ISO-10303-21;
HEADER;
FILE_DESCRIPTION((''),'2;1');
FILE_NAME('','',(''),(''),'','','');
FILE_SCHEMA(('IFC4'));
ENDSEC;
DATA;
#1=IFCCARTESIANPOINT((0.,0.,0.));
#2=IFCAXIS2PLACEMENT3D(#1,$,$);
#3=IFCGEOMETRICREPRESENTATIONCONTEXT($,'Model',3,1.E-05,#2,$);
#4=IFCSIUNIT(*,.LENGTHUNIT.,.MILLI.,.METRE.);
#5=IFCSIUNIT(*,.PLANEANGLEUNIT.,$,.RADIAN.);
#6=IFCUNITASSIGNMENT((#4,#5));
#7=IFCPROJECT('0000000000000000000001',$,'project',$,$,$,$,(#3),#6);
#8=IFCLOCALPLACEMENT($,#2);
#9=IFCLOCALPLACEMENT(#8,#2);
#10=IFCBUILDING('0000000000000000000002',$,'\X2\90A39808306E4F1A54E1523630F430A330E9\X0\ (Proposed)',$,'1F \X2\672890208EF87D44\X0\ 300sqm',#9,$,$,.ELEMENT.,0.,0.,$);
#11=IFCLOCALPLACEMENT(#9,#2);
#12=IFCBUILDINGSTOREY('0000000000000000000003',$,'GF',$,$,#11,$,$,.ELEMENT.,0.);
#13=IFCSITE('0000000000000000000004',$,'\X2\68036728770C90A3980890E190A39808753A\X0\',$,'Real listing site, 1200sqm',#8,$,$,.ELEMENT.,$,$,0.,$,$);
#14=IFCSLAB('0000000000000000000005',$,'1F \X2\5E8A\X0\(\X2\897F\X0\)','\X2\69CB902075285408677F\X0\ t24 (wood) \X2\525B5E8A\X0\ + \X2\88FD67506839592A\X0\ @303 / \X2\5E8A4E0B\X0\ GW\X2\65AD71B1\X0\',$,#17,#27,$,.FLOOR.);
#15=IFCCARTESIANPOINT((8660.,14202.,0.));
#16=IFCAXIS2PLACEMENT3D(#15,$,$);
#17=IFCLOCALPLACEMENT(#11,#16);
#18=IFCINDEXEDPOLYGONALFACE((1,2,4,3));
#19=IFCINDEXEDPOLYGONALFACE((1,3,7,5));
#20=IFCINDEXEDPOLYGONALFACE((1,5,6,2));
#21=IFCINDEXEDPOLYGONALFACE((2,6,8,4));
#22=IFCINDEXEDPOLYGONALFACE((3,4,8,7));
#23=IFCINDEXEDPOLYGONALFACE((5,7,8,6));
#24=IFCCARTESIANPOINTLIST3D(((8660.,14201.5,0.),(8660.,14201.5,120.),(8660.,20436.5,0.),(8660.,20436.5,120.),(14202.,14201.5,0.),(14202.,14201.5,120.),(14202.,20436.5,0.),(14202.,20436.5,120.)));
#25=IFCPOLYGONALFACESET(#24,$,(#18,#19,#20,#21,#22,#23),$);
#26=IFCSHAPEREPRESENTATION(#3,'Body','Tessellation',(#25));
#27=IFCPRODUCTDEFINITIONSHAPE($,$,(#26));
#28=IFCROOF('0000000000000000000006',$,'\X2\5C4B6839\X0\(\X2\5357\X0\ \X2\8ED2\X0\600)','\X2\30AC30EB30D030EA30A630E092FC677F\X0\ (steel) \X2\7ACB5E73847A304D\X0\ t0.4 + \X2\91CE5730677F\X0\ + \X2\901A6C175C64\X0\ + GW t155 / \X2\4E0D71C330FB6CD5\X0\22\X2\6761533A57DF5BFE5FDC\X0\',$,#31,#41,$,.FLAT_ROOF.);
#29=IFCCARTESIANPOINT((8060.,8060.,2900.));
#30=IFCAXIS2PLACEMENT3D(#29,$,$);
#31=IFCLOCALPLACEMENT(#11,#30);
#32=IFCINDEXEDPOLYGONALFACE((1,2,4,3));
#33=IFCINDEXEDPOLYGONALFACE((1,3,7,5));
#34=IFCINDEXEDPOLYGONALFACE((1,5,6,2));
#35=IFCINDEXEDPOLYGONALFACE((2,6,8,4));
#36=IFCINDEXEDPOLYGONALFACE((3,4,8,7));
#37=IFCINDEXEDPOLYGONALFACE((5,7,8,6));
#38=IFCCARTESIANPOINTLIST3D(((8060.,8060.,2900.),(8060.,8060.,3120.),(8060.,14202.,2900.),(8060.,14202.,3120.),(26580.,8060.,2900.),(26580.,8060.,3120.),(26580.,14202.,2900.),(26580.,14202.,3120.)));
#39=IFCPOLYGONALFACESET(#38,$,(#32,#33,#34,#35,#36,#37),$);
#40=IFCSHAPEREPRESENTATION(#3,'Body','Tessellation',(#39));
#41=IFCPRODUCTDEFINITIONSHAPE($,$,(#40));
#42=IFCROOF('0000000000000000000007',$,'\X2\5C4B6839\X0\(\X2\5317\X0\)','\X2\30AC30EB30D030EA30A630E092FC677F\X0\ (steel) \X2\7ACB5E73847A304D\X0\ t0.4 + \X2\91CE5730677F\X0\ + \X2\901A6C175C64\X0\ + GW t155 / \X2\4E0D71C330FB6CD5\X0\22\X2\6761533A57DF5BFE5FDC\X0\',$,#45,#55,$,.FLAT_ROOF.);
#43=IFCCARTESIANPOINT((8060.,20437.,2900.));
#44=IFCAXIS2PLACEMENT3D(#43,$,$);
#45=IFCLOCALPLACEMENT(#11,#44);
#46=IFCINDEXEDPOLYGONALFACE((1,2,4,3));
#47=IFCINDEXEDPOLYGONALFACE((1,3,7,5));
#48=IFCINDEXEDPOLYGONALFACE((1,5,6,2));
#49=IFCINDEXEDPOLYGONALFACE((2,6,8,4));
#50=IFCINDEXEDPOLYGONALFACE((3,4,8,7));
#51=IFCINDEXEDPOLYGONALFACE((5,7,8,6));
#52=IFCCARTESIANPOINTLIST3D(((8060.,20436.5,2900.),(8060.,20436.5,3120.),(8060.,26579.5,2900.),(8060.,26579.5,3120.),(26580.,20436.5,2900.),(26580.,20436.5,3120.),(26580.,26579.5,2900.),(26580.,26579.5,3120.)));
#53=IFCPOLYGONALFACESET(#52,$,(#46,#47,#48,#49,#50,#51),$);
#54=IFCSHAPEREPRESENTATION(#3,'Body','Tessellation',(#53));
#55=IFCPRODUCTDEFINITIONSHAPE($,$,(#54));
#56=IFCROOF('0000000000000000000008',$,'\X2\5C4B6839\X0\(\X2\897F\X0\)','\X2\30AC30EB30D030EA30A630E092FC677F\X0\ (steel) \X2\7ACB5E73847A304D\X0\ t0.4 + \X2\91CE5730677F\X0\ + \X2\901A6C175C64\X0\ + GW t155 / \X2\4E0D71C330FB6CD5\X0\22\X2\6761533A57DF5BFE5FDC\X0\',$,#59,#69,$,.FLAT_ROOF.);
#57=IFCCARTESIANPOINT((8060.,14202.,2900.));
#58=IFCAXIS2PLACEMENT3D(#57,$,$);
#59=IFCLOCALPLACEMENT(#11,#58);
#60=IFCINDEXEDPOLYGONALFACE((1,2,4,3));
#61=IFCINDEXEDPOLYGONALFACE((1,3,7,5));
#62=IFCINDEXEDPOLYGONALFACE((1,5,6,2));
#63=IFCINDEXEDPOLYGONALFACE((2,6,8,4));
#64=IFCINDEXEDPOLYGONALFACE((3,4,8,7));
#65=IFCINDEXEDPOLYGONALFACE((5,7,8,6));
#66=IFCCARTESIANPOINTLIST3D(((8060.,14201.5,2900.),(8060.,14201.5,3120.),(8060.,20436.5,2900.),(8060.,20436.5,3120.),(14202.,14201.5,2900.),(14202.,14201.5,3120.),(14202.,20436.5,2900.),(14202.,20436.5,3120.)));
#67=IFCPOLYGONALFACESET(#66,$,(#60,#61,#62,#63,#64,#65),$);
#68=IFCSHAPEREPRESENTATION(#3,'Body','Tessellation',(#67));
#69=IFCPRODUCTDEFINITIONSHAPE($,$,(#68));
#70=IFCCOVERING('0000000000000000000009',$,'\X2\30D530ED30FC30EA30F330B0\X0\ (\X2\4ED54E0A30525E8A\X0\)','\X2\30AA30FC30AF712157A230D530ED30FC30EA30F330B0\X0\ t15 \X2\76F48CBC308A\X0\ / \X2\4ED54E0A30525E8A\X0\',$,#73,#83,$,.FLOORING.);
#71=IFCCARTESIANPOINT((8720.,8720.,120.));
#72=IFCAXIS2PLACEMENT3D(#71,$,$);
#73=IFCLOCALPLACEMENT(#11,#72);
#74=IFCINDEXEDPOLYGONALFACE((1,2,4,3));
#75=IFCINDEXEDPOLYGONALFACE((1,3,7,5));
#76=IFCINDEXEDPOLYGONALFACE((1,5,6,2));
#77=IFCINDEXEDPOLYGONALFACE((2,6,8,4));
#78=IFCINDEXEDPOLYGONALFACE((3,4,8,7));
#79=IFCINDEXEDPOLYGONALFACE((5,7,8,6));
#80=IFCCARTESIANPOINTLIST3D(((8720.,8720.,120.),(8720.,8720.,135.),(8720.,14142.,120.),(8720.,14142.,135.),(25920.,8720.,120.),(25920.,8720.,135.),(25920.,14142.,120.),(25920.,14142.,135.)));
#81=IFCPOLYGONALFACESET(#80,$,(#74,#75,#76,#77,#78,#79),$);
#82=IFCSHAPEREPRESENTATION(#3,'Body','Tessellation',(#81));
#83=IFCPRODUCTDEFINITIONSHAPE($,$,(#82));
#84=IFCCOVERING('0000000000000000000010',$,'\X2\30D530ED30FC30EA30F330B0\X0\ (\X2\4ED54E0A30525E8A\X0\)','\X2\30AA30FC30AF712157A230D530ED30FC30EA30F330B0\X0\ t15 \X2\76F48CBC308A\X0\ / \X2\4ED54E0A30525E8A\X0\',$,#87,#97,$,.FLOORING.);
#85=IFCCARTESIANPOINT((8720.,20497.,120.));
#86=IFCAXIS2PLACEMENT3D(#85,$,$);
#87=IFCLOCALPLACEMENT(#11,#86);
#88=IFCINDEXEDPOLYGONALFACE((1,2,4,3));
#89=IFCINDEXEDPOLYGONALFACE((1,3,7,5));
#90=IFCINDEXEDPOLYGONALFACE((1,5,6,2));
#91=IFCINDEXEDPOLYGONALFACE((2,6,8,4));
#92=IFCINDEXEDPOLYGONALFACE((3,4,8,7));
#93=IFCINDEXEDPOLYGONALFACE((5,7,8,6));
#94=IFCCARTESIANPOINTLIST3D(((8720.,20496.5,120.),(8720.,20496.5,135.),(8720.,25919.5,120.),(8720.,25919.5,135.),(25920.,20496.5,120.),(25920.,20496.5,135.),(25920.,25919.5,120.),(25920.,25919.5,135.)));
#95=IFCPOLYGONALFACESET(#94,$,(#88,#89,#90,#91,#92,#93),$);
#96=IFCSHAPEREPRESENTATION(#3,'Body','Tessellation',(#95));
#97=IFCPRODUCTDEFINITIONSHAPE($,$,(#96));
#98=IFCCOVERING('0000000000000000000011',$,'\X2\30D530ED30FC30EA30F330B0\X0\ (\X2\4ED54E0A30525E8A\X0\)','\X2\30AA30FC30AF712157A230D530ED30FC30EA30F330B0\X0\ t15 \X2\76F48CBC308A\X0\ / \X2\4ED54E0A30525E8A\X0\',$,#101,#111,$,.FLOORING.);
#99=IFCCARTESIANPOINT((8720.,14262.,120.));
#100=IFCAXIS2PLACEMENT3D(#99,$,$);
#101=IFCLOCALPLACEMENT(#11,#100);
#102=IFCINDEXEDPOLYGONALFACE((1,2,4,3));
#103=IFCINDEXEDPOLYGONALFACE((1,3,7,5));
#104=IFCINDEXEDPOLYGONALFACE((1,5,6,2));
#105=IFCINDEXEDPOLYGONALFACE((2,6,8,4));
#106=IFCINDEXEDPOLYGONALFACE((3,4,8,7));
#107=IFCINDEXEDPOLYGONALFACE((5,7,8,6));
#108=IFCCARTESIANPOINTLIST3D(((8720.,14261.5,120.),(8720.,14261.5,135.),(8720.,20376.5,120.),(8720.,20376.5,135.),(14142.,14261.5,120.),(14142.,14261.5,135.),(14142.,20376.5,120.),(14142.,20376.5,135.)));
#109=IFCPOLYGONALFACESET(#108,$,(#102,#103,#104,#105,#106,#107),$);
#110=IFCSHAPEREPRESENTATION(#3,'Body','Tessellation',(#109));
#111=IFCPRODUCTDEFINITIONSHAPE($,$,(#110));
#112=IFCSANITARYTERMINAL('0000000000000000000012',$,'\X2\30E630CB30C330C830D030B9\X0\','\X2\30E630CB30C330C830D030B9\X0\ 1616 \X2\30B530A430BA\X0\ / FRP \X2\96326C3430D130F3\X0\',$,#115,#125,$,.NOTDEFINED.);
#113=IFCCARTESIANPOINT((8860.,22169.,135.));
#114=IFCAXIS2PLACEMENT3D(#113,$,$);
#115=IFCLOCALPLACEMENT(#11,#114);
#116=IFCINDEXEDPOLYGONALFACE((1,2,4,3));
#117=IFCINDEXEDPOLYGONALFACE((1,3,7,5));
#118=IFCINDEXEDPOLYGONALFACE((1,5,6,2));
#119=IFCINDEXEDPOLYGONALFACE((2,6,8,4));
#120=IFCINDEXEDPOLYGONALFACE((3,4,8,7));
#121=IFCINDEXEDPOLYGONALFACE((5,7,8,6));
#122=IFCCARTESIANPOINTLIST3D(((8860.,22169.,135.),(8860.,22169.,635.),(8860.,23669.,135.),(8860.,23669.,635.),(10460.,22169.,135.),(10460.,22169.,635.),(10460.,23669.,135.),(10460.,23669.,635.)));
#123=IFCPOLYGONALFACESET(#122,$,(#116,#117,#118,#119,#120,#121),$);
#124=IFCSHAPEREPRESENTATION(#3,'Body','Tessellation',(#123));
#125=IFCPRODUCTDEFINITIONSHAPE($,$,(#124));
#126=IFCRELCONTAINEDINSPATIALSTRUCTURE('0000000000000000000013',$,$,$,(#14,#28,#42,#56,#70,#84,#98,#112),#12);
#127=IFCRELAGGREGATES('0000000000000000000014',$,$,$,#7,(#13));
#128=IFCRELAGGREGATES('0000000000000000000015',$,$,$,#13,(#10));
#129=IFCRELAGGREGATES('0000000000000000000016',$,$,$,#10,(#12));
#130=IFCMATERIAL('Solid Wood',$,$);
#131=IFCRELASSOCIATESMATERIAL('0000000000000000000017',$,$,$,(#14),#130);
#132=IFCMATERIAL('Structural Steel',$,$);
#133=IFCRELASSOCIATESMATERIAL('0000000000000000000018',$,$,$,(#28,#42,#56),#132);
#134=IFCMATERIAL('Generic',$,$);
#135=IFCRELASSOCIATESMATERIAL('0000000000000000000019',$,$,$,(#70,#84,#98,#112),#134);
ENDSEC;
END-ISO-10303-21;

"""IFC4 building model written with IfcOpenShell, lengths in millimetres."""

from ifc_helpers import new_model, si_unit, frame, frame_2d, origin, place, context, project, spatial, rectangle, extrude, material, element, save


model = new_model("IFC4")

# Units and contexts
model_context = context("Model", 3, precision=1e-05, world=origin())
ifc_project = project(units=[si_unit("LENGTHUNIT", "METRE", prefix="MILLI"), si_unit("PLANEANGLEUNIT", "RADIAN")], contexts=[model_context])

# Site, building, storey
site_placement = place(None, origin())
site = spatial("IfcSite", under=ifc_project, at=site_placement, Name="栃木県那須郡那須町", ObjectType="Real listing site, 1200sqm", CompositionType="ELEMENT", RefElevation=0.0)
building_placement = place(site_placement, origin())
building = spatial("IfcBuilding", under=site, at=building_placement, Name="那須の会員制ヴィラ (Proposed)", ObjectType="1F 木造軸組 300sqm", CompositionType="ELEMENT", ElevationOfRefHeight=0.0, ElevationOfTerrain=0.0)
storey_placement = place(building_placement, origin())
storey = spatial("IfcBuildingStorey", under=building, at=storey_placement, Name="GF", CompositionType="ELEMENT", Elevation=0.0)

# Slab
ifc_material_1 = material(Name="Solid Wood")
slab_1_placement = place(storey_placement, frame((8660.0, 14202.0, 0.0)))
element("IfcSlab", 1, at=slab_1_placement, inside=storey, material=ifc_material_1, Name="1F 床(西)", Description="構造用合板 t24 (wood) 剛床 + 製材根太 @303 / 床下 GW断熱", PredefinedType="FLOOR", context=model_context, shape_type="SweptSolid", body=[
    extrude(rectangle(XDim=5542.0, YDim=6235.0, at=frame_2d((2771.0, 3117.0))), frame((8660.0, 14202.0, 0.0)), (0.0, 0.0, 1.0), 120.0),
])

# Roofs
ifc_material_2 = material(Name="Structural Steel")
roof_1_placement = place(storey_placement, frame((8060.0, 8060.0, 2900.0)))
element("IfcRoof", 2, at=roof_1_placement, inside=storey, material=ifc_material_2, Name="屋根(南 軒600)", Description="ガルバリウム鋼板 (steel) 立平葺き t0.4 + 野地板 + 通気層 + GW t155 / 不燃・法22条区域対応", PredefinedType="FLAT_ROOF", context=model_context, shape_type="SweptSolid", body=[
    extrude(rectangle(XDim=18520.0, YDim=6142.0, at=frame_2d((9260.0, 3071.0))), frame((8060.0, 8060.0, 2900.0)), (0.0, 0.0, 1.0), 220.0),
])
roof_2_placement = place(storey_placement, frame((8060.0, 20437.0, 2900.0)))
element("IfcRoof", 3, at=roof_2_placement, inside=storey, material=ifc_material_2, Name="屋根(北)", Description="ガルバリウム鋼板 (steel) 立平葺き t0.4 + 野地板 + 通気層 + GW t155 / 不燃・法22条区域対応", PredefinedType="FLAT_ROOF", context=model_context, shape_type="SweptSolid", body=[
    extrude(rectangle(XDim=18520.0, YDim=6143.0, at=frame_2d((9260.0, 3071.0))), frame((8060.0, 20437.0, 2900.0)), (0.0, 0.0, 1.0), 220.0),
])
roof_3_placement = place(storey_placement, frame((8060.0, 14202.0, 2900.0)))
element("IfcRoof", 4, at=roof_3_placement, inside=storey, material=ifc_material_2, Name="屋根(西)", Description="ガルバリウム鋼板 (steel) 立平葺き t0.4 + 野地板 + 通気層 + GW t155 / 不燃・法22条区域対応", PredefinedType="FLAT_ROOF", context=model_context, shape_type="SweptSolid", body=[
    extrude(rectangle(XDim=6142.0, YDim=6235.0, at=frame_2d((3071.0, 3117.0))), frame((8060.0, 14202.0, 2900.0)), (0.0, 0.0, 1.0), 220.0),
])

# Coverings
ifc_material_3 = material(Name="Generic")
covering_1_placement = place(storey_placement, frame((8720.0, 8720.0, 120.0)))
element("IfcCovering", 5, at=covering_1_placement, inside=storey, material=ifc_material_3, Name="フローリング (仕上げ床)", Description="オーク無垢フローリング t15 直貼り / 仕上げ床", PredefinedType="FLOORING", context=model_context, shape_type="SweptSolid", body=[
    extrude(rectangle(XDim=17200.0, YDim=5422.0, at=frame_2d((8600.0, 2711.0))), frame((8720.0, 8720.0, 120.0)), (0.0, 0.0, 1.0), 15.0),
])
covering_2_placement = place(storey_placement, frame((8720.0, 20497.0, 120.0)))
element("IfcCovering", 6, at=covering_2_placement, inside=storey, material=ifc_material_3, Name="フローリング (仕上げ床)", Description="オーク無垢フローリング t15 直貼り / 仕上げ床", PredefinedType="FLOORING", context=model_context, shape_type="SweptSolid", body=[
    extrude(rectangle(XDim=17200.0, YDim=5423.0, at=frame_2d((8600.0, 2711.0))), frame((8720.0, 20497.0, 120.0)), (0.0, 0.0, 1.0), 15.0),
])
covering_3_placement = place(storey_placement, frame((8720.0, 14262.0, 120.0)))
element("IfcCovering", 7, at=covering_3_placement, inside=storey, material=ifc_material_3, Name="フローリング (仕上げ床)", Description="オーク無垢フローリング t15 直貼り / 仕上げ床", PredefinedType="FLOORING", context=model_context, shape_type="SweptSolid", body=[
    extrude(rectangle(XDim=5422.0, YDim=6115.0, at=frame_2d((2711.0, 3057.0))), frame((8720.0, 14262.0, 120.0)), (0.0, 0.0, 1.0), 15.0),
])

# Sanitary terminal
sanitary_terminal_placement = place(storey_placement, frame((8860.0, 22169.0, 135.0)))
element("IfcSanitaryTerminal", 8, at=sanitary_terminal_placement, inside=storey, material=ifc_material_3, Name="ユニットバス", Description="ユニットバス 1616 サイズ / FRP 防水パン", PredefinedType="NOTDEFINED", context=model_context, shape_type="SweptSolid", body=[
    extrude(rectangle(XDim=1600.0, YDim=1500.0, at=frame_2d((800.0, 750.0))), frame((8860.0, 22169.0, 135.0)), (0.0, 0.0, 1.0), 500.0),
])

save(model, "model.ifc")
